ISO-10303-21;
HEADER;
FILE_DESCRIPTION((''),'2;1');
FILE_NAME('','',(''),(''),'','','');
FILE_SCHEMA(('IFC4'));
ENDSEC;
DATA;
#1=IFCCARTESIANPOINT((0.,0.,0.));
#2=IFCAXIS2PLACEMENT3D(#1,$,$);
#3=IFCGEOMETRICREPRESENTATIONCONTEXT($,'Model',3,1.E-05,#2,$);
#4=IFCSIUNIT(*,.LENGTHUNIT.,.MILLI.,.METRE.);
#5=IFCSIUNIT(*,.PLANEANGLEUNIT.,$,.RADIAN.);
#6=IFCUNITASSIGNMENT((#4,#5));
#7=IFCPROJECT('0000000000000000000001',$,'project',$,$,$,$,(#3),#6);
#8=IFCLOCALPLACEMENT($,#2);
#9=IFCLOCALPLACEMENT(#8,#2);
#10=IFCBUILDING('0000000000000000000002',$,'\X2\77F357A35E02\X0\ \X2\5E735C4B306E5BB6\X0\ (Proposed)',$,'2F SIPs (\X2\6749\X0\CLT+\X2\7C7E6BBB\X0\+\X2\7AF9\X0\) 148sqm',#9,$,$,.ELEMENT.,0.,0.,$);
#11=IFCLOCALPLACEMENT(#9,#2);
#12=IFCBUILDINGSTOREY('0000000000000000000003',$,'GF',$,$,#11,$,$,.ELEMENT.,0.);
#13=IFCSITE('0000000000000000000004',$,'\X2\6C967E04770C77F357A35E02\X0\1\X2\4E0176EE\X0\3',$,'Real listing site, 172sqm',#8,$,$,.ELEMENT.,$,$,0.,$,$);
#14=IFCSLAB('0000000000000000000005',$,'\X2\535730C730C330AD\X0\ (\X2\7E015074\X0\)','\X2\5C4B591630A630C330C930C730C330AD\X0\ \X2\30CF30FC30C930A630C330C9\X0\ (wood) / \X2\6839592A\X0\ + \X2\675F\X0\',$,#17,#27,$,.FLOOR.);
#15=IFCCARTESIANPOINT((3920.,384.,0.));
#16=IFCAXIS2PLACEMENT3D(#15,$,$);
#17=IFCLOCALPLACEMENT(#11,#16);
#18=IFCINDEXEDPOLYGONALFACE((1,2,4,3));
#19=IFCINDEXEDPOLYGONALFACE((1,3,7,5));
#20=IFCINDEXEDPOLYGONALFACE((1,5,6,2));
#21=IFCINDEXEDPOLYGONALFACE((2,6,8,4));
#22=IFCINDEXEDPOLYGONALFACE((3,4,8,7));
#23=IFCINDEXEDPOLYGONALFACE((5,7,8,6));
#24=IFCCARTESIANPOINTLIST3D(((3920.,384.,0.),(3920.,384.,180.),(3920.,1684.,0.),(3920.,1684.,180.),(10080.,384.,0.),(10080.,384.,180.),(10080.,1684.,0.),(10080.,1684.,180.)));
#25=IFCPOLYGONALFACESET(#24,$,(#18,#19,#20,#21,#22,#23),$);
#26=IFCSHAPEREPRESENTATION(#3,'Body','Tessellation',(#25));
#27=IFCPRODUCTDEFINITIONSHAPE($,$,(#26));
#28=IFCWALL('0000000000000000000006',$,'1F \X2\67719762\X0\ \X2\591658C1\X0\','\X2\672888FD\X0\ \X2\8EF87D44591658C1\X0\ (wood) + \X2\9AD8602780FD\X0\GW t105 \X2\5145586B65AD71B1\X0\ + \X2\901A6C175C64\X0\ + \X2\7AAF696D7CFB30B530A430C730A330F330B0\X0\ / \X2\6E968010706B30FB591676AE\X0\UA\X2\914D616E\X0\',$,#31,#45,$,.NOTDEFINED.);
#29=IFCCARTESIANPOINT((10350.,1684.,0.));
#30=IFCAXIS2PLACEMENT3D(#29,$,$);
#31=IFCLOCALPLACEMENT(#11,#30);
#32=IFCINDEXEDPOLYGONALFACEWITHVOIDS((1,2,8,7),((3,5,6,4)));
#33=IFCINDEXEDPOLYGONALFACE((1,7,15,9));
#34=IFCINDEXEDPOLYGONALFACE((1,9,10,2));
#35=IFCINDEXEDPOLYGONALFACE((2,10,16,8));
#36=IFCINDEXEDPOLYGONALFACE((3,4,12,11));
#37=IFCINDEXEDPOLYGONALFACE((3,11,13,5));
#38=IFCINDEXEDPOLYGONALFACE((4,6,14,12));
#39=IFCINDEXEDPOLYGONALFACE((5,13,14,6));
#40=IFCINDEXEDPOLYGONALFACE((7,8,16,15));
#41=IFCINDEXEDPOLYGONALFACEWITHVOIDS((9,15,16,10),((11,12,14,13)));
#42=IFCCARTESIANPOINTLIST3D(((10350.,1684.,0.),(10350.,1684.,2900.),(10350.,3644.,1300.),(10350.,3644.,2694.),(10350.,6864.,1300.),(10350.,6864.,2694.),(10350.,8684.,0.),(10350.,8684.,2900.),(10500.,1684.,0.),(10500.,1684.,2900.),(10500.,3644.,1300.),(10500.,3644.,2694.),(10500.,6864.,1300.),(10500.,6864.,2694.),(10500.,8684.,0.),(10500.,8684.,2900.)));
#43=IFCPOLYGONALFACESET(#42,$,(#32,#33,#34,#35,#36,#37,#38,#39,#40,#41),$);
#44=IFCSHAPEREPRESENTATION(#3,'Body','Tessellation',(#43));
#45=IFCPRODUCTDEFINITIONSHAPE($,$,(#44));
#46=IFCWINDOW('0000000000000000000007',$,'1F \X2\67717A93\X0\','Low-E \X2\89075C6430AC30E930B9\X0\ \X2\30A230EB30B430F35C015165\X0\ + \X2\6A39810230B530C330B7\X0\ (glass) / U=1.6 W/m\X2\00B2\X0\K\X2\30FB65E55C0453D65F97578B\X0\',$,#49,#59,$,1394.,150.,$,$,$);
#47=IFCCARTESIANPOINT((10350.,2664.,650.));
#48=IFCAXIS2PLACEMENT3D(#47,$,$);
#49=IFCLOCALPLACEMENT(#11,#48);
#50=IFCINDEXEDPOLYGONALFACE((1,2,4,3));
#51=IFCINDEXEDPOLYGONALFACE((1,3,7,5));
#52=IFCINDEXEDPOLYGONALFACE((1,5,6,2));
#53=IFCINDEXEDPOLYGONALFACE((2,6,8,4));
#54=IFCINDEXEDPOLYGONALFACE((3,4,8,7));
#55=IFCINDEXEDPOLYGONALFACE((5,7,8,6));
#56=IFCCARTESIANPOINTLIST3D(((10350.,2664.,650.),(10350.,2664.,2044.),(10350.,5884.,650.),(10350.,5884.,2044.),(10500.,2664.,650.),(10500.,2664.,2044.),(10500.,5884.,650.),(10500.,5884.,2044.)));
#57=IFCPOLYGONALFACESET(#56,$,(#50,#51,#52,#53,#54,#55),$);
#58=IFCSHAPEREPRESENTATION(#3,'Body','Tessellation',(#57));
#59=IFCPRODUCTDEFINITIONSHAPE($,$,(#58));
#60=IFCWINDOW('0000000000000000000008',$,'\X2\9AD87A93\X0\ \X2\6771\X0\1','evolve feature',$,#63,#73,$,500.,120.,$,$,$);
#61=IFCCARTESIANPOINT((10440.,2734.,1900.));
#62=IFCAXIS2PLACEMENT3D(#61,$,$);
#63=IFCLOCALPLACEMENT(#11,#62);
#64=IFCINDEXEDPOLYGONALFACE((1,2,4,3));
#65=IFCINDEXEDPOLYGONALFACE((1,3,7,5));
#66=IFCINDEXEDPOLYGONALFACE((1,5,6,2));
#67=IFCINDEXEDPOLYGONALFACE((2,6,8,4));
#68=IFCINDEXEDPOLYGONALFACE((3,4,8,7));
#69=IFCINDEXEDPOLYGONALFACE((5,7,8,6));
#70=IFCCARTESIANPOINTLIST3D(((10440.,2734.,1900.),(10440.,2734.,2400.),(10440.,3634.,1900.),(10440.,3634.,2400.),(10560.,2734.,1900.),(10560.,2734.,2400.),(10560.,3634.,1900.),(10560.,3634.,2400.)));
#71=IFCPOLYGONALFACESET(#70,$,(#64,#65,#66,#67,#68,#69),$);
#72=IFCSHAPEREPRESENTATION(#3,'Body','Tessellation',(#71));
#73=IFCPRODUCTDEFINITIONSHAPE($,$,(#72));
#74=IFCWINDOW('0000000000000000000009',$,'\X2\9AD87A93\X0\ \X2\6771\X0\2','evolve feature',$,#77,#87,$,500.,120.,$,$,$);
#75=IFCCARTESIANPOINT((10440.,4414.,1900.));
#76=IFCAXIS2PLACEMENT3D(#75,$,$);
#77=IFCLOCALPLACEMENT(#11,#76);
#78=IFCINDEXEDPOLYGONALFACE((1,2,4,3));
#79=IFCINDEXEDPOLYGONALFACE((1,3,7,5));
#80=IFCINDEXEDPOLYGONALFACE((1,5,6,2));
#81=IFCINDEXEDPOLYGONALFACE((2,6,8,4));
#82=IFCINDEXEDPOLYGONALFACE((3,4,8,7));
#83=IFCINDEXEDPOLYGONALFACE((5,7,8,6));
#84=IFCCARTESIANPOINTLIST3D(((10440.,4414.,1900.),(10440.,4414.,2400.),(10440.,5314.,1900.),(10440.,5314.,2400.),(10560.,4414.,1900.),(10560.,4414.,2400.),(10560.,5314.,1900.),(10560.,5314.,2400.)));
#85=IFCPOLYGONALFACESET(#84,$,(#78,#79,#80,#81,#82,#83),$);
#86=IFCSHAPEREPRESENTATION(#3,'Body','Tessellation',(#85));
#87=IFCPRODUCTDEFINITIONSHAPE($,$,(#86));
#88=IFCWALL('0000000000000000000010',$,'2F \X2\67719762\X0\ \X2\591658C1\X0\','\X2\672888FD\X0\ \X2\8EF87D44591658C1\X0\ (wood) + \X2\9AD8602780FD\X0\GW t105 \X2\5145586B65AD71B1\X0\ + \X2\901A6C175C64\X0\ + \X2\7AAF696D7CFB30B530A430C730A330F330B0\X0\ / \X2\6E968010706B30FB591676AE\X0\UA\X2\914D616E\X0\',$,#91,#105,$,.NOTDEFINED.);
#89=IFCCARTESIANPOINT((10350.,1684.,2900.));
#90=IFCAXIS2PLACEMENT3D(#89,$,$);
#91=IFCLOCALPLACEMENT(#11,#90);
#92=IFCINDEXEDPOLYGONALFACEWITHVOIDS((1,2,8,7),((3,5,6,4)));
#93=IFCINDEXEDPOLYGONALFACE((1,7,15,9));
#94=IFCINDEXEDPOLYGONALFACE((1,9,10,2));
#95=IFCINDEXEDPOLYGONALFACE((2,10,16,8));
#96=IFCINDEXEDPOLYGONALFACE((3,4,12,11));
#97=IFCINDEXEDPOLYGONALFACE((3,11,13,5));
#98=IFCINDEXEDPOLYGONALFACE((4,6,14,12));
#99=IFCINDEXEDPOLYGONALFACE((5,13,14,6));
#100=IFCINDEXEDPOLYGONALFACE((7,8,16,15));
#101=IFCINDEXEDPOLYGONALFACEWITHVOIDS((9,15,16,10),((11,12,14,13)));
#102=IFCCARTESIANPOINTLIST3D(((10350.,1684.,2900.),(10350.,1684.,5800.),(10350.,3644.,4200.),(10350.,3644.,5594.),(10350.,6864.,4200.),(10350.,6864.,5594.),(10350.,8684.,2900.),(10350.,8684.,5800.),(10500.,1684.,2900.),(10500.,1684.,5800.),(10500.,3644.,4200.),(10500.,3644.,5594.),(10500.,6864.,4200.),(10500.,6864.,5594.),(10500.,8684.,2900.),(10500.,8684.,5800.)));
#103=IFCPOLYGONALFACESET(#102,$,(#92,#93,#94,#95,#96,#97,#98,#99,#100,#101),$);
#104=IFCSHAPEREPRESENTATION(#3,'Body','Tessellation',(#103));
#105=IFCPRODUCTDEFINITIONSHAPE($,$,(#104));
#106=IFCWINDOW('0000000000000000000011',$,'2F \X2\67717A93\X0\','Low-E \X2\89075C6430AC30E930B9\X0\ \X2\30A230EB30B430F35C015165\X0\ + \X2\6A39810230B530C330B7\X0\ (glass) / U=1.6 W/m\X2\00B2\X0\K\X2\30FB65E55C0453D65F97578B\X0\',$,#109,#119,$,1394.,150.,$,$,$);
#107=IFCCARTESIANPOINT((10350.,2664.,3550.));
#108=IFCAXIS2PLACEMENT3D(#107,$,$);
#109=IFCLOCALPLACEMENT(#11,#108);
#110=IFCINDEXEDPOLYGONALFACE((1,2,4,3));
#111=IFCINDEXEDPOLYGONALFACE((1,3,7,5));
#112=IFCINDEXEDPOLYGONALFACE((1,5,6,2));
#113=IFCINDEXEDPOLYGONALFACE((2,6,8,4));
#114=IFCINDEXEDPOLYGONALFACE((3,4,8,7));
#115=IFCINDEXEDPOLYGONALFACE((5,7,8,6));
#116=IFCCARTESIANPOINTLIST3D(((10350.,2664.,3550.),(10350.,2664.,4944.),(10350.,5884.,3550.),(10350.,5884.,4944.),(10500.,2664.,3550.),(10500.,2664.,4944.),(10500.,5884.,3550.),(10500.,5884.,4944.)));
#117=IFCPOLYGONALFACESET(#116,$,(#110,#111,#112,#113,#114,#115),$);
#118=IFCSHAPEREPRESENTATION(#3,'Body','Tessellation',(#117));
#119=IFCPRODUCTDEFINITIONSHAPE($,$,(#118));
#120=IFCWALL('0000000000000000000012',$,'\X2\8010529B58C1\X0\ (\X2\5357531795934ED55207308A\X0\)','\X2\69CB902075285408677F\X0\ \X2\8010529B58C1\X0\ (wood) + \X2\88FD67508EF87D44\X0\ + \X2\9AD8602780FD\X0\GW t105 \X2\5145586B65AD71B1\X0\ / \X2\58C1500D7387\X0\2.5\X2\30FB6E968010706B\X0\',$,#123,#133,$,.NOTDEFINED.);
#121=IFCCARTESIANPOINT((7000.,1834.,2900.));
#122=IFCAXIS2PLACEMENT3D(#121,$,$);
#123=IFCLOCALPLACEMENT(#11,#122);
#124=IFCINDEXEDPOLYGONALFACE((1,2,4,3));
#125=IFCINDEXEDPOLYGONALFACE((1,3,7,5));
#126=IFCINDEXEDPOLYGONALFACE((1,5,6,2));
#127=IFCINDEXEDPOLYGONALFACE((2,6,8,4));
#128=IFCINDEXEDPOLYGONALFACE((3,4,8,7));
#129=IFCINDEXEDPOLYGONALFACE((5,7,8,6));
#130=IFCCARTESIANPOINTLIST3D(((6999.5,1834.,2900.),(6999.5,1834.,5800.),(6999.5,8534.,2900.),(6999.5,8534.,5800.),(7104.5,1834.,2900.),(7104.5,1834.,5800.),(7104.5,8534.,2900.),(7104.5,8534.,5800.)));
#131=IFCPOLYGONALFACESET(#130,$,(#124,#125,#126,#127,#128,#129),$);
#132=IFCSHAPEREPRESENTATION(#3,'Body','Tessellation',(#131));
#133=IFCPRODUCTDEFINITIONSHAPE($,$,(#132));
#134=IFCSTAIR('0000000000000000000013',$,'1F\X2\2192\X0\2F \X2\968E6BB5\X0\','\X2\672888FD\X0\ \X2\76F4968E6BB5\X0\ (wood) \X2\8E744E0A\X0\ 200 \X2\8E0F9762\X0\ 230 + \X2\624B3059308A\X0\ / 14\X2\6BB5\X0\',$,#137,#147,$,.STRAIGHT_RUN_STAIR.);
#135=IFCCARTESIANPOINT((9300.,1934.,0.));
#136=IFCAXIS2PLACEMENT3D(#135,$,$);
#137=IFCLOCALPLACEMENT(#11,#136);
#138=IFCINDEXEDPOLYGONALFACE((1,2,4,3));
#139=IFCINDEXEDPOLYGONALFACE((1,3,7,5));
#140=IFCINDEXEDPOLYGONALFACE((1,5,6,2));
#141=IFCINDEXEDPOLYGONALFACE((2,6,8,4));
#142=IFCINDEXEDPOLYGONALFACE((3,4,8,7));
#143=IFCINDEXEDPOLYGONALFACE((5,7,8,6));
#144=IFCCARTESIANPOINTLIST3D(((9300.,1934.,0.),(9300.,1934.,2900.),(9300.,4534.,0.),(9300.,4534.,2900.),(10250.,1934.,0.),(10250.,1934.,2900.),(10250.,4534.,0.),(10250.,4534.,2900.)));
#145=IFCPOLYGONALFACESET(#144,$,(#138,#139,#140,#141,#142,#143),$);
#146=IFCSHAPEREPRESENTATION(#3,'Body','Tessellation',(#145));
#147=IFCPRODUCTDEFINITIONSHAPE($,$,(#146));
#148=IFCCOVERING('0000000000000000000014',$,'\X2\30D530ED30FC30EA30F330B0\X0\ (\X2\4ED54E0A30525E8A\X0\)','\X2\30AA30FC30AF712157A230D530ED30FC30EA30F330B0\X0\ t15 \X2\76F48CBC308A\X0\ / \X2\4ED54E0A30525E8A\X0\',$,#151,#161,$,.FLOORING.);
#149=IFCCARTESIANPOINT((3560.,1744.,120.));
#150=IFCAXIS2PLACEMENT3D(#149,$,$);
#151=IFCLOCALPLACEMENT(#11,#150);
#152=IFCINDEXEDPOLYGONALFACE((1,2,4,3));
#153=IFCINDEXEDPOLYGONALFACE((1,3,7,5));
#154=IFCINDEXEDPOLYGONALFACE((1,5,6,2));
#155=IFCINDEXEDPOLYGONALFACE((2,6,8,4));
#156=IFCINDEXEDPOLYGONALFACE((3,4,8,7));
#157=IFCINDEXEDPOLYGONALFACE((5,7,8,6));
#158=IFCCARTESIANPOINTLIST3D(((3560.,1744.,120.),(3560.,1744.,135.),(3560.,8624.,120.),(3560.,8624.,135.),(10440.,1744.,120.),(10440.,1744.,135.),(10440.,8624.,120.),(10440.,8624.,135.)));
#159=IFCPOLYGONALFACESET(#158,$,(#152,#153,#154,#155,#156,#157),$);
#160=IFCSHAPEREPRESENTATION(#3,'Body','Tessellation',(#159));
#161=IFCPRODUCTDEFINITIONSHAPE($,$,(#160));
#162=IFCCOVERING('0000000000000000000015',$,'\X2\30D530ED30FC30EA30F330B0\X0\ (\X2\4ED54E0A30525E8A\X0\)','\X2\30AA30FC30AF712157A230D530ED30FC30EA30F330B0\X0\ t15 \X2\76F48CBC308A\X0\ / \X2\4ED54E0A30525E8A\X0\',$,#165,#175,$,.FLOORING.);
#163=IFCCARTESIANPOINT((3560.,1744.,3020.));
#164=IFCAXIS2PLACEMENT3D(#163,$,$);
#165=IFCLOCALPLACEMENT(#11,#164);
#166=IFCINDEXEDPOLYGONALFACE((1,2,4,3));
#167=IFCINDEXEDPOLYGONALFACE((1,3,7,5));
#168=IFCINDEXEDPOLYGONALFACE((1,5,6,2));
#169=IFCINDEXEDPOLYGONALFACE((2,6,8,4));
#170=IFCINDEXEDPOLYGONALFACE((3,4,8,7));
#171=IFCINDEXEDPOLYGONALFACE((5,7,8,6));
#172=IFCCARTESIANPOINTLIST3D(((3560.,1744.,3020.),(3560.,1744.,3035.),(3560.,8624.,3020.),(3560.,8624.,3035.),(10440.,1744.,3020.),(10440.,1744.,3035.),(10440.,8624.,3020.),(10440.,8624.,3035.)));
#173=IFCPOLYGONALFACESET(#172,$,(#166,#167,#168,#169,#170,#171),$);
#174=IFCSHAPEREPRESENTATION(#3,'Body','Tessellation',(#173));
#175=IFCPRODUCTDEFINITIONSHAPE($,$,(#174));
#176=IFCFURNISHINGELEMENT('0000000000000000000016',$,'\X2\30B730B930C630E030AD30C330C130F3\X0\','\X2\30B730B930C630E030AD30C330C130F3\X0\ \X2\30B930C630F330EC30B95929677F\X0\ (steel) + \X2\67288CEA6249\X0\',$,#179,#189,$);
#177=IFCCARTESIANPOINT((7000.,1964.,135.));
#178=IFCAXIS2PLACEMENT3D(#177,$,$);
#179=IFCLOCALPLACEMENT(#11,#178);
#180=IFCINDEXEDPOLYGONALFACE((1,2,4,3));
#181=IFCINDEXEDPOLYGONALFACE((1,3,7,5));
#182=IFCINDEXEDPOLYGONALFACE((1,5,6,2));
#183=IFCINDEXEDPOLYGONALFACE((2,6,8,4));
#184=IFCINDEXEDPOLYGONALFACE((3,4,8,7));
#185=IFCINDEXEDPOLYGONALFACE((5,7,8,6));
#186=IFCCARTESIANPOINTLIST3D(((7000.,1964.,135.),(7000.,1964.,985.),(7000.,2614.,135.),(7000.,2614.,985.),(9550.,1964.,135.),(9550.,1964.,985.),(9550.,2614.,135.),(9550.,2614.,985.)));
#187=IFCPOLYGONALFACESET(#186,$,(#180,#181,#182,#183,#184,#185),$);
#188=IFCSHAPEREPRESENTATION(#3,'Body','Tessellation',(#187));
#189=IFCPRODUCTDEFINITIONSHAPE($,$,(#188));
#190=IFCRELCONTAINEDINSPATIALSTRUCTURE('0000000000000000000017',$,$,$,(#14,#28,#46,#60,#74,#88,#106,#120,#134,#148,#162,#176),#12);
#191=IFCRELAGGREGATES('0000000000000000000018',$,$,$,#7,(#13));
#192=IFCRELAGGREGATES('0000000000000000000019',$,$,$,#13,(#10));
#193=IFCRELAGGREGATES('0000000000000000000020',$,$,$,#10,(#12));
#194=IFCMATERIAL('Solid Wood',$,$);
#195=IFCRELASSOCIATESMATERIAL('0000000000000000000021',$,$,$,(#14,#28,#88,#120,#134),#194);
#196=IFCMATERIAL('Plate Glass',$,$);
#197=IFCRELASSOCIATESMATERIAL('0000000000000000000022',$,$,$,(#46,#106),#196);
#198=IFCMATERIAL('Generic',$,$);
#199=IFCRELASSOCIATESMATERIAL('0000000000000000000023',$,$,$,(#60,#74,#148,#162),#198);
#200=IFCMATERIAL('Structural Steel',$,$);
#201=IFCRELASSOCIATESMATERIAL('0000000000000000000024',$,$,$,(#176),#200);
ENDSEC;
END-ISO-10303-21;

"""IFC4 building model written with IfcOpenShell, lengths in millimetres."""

from ifc_helpers import new_model, si_unit, frame, frame_2d, origin, place, context, project, spatial, rectangle, extrude, material, element, fill, save


model = new_model("IFC4")

# Units and contexts
model_context = context("Model", 3, precision=1e-05, world=origin())
ifc_project = project(units=[si_unit("LENGTHUNIT", "METRE", prefix="MILLI"), si_unit("PLANEANGLEUNIT", "RADIAN")], contexts=[model_context])

# Site, building, storey
site_placement = place(None, origin())
site = spatial("IfcSite", under=ifc_project, at=site_placement, Name="沖縄県石垣市1丁目3", ObjectType="Real listing site, 172sqm", CompositionType="ELEMENT", RefElevation=0.0)
building_placement = place(site_placement, origin())
building = spatial("IfcBuilding", under=site, at=building_placement, Name="石垣市 平屋の家 (Proposed)", ObjectType="2F SIPs (杉CLT+籾殻+竹) 148sqm", CompositionType="ELEMENT", ElevationOfRefHeight=0.0, ElevationOfTerrain=0.0)
storey_placement = place(building_placement, origin())
storey = spatial("IfcBuildingStorey", under=building, at=storey_placement, Name="GF", CompositionType="ELEMENT", Elevation=0.0)

# Slab
ifc_material_1 = material(Name="Solid Wood")
slab_placement = place(storey_placement, frame((3920.0, 384.0, 0.0)))
element("IfcSlab", 1, at=slab_placement, inside=storey, material=ifc_material_1, Name="南デッキ (縁側)", Description="屋外ウッドデッキ ハードウッド (wood) / 根太 + 束", PredefinedType="FLOOR", context=model_context, shape_type="SweptSolid", body=[
    extrude(rectangle(XDim=6160.0, YDim=1300.0, at=frame_2d((3080.0, 650.0))), frame((3920.0, 384.0, 0.0)), (0.0, 0.0, 1.0), 180.0),
])

# Wall, openings, windows
wall_1_placement = place(storey_placement, frame((10350.0, 1684.0, 0.0)))
wall_1 = element("IfcWall", 2, at=wall_1_placement, inside=storey, material=ifc_material_1, Name="1F 東面 外壁", Description="木製 軸組外壁 (wood) + 高性能GW t105 充填断熱 + 通気層 + 窯業系サイディング / 準耐火・外皮UA配慮", PredefinedType="NOTDEFINED", context=model_context, shape_type="SweptSolid", body=[
    extrude(rectangle(XDim=150.0, YDim=7000.0, at=frame_2d((75.0, 3500.0))), frame((10350.0, 1684.0, 0.0)), (0.0, 0.0, 1.0), 2900.0),
])
opening_1_placement = place(storey_placement, frame((10350.0, 2664.0, 650.0)))
opening_1 = element("IfcOpeningElement", 3, at=opening_1_placement, cuts=wall_1, PredefinedType="NOTDEFINED", context=model_context, shape_type="SweptSolid", body=[
    extrude(rectangle(XDim=150.0, YDim=3220.0, at=frame_2d((75.0, 1610.0))), frame((10350.0, 2664.0, 650.0)), (0.0, 0.0, 1.0), 1394.0),
])
opening_2_placement = place(storey_placement, frame((10440.0, 2734.0, 1900.0)))
opening_2 = element("IfcOpeningElement", 4, at=opening_2_placement, cuts=wall_1, PredefinedType="NOTDEFINED", context=model_context, shape_type="SweptSolid", body=[
    extrude(rectangle(XDim=120.0, YDim=900.0, at=frame_2d((60.0, 450.0))), frame((10440.0, 2734.0, 1900.0)), (0.0, 0.0, 1.0), 500.0),
])
opening_3_placement = place(storey_placement, frame((10440.0, 4414.0, 1900.0)))
opening_3 = element("IfcOpeningElement", 5, at=opening_3_placement, cuts=wall_1, PredefinedType="NOTDEFINED", context=model_context, shape_type="SweptSolid", body=[
    extrude(rectangle(XDim=120.0, YDim=900.0, at=frame_2d((60.0, 450.0))), frame((10440.0, 4414.0, 1900.0)), (0.0, 0.0, 1.0), 500.0),
])
ifc_material_2 = material(Name="Plate Glass")
window_1_placement = place(storey_placement, frame((10350.0, 2664.0, 650.0)))
window_1 = element("IfcWindow", 6, at=window_1_placement, inside=storey, material=ifc_material_2, Name="1F 東窓", Description="Low-E 複層ガラス アルゴン封入 + 樹脂サッシ (glass) / U=1.6 W/m²K・日射取得型", OverallHeight=1394.0, OverallWidth=150.0, context=model_context, shape_type="SweptSolid", body=[
    extrude(rectangle(XDim=150.0, YDim=3220.0, at=frame_2d((75.0, 1610.0))), frame((10350.0, 2664.0, 650.0)), (0.0, 0.0, 1.0), 1394.0),
])
fill(opening_1, window_1)
ifc_material_3 = material(Name="Generic")
window_2_placement = place(storey_placement, frame((10440.0, 2734.0, 1900.0)))
window_2 = element("IfcWindow", 7, at=window_2_placement, inside=storey, material=ifc_material_3, Name="高窓 東1", Description="evolve feature", OverallHeight=500.0, OverallWidth=120.0, context=model_context, shape_type="SweptSolid", body=[
    extrude(rectangle(XDim=120.0, YDim=900.0, at=frame_2d((60.0, 450.0))), frame((10440.0, 2734.0, 1900.0)), (0.0, 0.0, 1.0), 500.0),
])
fill(opening_2, window_2)
window_3_placement = place(storey_placement, frame((10440.0, 4414.0, 1900.0)))
window_3 = element("IfcWindow", 8, at=window_3_placement, inside=storey, material=ifc_material_3, Name="高窓 東2", Description="evolve feature", OverallHeight=500.0, OverallWidth=120.0, context=model_context, shape_type="SweptSolid", body=[
    extrude(rectangle(XDim=120.0, YDim=900.0, at=frame_2d((60.0, 450.0))), frame((10440.0, 4414.0, 1900.0)), (0.0, 0.0, 1.0), 500.0),
])
fill(opening_3, window_3)

# Wall, opening, window
wall_2_placement = place(storey_placement, frame((10350.0, 1684.0, 2900.0)))
wall_2 = element("IfcWall", 9, at=wall_2_placement, inside=storey, material=ifc_material_1, Name="2F 東面 外壁", Description="木製 軸組外壁 (wood) + 高性能GW t105 充填断熱 + 通気層 + 窯業系サイディング / 準耐火・外皮UA配慮", PredefinedType="NOTDEFINED", context=model_context, shape_type="SweptSolid", body=[
    extrude(rectangle(XDim=150.0, YDim=7000.0, at=frame_2d((75.0, 3500.0))), frame((10350.0, 1684.0, 2900.0)), (0.0, 0.0, 1.0), 2900.0),
])
opening_4_placement = place(storey_placement, frame((10350.0, 2664.0, 3550.0)))
opening_4 = element("IfcOpeningElement", 10, at=opening_4_placement, cuts=wall_2, PredefinedType="NOTDEFINED", context=model_context, shape_type="SweptSolid", body=[
    extrude(rectangle(XDim=150.0, YDim=3220.0, at=frame_2d((75.0, 1610.0))), frame((10350.0, 2664.0, 3550.0)), (0.0, 0.0, 1.0), 1394.0),
])
window_4_placement = place(storey_placement, frame((10350.0, 2664.0, 3550.0)))
window_4 = element("IfcWindow", 11, at=window_4_placement, inside=storey, material=ifc_material_2, Name="2F 東窓", Description="Low-E 複層ガラス アルゴン封入 + 樹脂サッシ (glass) / U=1.6 W/m²K・日射取得型", OverallHeight=1394.0, OverallWidth=150.0, context=model_context, shape_type="SweptSolid", body=[
    extrude(rectangle(XDim=150.0, YDim=3220.0, at=frame_2d((75.0, 1610.0))), frame((10350.0, 2664.0, 3550.0)), (0.0, 0.0, 1.0), 1394.0),
])
fill(opening_4, window_4)

# Wall
wall_3_placement = place(storey_placement, frame((7000.0, 1834.0, 2900.0)))
element("IfcWall", 12, at=wall_3_placement, inside=storey, material=ifc_material_1, Name="耐力壁 (南北間仕切り)", Description="構造用合板 耐力壁 (wood) + 製材軸組 + 高性能GW t105 充填断熱 / 壁倍率2.5・準耐火", PredefinedType="NOTDEFINED", context=model_context, shape_type="SweptSolid", body=[
    extrude(rectangle(XDim=105.0, YDim=6700.0, at=frame_2d((52.0, 3350.0))), frame((7000.0, 1834.0, 2900.0)), (0.0, 0.0, 1.0), 2900.0),
])

# Stair
stair_placement = place(storey_placement, frame((9300.0, 1934.0, 0.0)))
element("IfcStair", 13, at=stair_placement, inside=storey, material=ifc_material_1, Name="1F→2F 階段", Description="木製 直階段 (wood) 蹴上 200 踏面 230 + 手すり / 14段", PredefinedType="STRAIGHT_RUN_STAIR", context=model_context, shape_type="SweptSolid", body=[
    extrude(rectangle(XDim=950.0, YDim=2600.0, at=frame_2d((475.0, 1300.0))), frame((9300.0, 1934.0, 0.0)), (0.0, 0.0, 1.0), 2900.0),
])

# Coverings
covering_1_placement = place(storey_placement, frame((3560.0, 1744.0, 120.0)))
element("IfcCovering", 14, at=covering_1_placement, inside=storey, material=ifc_material_3, Name="フローリング (仕上げ床)", Description="オーク無垢フローリング t15 直貼り / 仕上げ床", PredefinedType="FLOORING", context=model_context, shape_type="SweptSolid", body=[
    extrude(rectangle(XDim=6880.0, YDim=6880.0, at=frame_2d((3440.0, 3440.0))), frame((3560.0, 1744.0, 120.0)), (0.0, 0.0, 1.0), 15.0),
])
covering_2_placement = place(storey_placement, frame((3560.0, 1744.0, 3020.0)))
element("IfcCovering", 15, at=covering_2_placement, inside=storey, material=ifc_material_3, Name="フローリング (仕上げ床)", Description="オーク無垢フローリング t15 直貼り / 仕上げ床", PredefinedType="FLOORING", context=model_context, shape_type="SweptSolid", body=[
    extrude(rectangle(XDim=6880.0, YDim=6880.0, at=frame_2d((3440.0, 3440.0))), frame((3560.0, 1744.0, 3020.0)), (0.0, 0.0, 1.0), 15.0),
])

# Furnishing element
ifc_material_4 = material(Name="Structural Steel")
furnishing_1_placement = place(storey_placement, frame((7000.0, 1964.0, 135.0)))
element("IfcFurnishingElement", 16, at=furnishing_1_placement, inside=storey, material=ifc_material_4, Name="システムキッチン", Description="システムキッチン ステンレス天板 (steel) + 木質扉", context=model_context, shape_type="SweptSolid", body=[
    extrude(rectangle(XDim=2550.0, YDim=650.0, at=frame_2d((1275.0, 325.0))), frame((7000.0, 1964.0, 135.0)), (0.0, 0.0, 1.0), 850.0),
])

save(model, "model.ifc")
